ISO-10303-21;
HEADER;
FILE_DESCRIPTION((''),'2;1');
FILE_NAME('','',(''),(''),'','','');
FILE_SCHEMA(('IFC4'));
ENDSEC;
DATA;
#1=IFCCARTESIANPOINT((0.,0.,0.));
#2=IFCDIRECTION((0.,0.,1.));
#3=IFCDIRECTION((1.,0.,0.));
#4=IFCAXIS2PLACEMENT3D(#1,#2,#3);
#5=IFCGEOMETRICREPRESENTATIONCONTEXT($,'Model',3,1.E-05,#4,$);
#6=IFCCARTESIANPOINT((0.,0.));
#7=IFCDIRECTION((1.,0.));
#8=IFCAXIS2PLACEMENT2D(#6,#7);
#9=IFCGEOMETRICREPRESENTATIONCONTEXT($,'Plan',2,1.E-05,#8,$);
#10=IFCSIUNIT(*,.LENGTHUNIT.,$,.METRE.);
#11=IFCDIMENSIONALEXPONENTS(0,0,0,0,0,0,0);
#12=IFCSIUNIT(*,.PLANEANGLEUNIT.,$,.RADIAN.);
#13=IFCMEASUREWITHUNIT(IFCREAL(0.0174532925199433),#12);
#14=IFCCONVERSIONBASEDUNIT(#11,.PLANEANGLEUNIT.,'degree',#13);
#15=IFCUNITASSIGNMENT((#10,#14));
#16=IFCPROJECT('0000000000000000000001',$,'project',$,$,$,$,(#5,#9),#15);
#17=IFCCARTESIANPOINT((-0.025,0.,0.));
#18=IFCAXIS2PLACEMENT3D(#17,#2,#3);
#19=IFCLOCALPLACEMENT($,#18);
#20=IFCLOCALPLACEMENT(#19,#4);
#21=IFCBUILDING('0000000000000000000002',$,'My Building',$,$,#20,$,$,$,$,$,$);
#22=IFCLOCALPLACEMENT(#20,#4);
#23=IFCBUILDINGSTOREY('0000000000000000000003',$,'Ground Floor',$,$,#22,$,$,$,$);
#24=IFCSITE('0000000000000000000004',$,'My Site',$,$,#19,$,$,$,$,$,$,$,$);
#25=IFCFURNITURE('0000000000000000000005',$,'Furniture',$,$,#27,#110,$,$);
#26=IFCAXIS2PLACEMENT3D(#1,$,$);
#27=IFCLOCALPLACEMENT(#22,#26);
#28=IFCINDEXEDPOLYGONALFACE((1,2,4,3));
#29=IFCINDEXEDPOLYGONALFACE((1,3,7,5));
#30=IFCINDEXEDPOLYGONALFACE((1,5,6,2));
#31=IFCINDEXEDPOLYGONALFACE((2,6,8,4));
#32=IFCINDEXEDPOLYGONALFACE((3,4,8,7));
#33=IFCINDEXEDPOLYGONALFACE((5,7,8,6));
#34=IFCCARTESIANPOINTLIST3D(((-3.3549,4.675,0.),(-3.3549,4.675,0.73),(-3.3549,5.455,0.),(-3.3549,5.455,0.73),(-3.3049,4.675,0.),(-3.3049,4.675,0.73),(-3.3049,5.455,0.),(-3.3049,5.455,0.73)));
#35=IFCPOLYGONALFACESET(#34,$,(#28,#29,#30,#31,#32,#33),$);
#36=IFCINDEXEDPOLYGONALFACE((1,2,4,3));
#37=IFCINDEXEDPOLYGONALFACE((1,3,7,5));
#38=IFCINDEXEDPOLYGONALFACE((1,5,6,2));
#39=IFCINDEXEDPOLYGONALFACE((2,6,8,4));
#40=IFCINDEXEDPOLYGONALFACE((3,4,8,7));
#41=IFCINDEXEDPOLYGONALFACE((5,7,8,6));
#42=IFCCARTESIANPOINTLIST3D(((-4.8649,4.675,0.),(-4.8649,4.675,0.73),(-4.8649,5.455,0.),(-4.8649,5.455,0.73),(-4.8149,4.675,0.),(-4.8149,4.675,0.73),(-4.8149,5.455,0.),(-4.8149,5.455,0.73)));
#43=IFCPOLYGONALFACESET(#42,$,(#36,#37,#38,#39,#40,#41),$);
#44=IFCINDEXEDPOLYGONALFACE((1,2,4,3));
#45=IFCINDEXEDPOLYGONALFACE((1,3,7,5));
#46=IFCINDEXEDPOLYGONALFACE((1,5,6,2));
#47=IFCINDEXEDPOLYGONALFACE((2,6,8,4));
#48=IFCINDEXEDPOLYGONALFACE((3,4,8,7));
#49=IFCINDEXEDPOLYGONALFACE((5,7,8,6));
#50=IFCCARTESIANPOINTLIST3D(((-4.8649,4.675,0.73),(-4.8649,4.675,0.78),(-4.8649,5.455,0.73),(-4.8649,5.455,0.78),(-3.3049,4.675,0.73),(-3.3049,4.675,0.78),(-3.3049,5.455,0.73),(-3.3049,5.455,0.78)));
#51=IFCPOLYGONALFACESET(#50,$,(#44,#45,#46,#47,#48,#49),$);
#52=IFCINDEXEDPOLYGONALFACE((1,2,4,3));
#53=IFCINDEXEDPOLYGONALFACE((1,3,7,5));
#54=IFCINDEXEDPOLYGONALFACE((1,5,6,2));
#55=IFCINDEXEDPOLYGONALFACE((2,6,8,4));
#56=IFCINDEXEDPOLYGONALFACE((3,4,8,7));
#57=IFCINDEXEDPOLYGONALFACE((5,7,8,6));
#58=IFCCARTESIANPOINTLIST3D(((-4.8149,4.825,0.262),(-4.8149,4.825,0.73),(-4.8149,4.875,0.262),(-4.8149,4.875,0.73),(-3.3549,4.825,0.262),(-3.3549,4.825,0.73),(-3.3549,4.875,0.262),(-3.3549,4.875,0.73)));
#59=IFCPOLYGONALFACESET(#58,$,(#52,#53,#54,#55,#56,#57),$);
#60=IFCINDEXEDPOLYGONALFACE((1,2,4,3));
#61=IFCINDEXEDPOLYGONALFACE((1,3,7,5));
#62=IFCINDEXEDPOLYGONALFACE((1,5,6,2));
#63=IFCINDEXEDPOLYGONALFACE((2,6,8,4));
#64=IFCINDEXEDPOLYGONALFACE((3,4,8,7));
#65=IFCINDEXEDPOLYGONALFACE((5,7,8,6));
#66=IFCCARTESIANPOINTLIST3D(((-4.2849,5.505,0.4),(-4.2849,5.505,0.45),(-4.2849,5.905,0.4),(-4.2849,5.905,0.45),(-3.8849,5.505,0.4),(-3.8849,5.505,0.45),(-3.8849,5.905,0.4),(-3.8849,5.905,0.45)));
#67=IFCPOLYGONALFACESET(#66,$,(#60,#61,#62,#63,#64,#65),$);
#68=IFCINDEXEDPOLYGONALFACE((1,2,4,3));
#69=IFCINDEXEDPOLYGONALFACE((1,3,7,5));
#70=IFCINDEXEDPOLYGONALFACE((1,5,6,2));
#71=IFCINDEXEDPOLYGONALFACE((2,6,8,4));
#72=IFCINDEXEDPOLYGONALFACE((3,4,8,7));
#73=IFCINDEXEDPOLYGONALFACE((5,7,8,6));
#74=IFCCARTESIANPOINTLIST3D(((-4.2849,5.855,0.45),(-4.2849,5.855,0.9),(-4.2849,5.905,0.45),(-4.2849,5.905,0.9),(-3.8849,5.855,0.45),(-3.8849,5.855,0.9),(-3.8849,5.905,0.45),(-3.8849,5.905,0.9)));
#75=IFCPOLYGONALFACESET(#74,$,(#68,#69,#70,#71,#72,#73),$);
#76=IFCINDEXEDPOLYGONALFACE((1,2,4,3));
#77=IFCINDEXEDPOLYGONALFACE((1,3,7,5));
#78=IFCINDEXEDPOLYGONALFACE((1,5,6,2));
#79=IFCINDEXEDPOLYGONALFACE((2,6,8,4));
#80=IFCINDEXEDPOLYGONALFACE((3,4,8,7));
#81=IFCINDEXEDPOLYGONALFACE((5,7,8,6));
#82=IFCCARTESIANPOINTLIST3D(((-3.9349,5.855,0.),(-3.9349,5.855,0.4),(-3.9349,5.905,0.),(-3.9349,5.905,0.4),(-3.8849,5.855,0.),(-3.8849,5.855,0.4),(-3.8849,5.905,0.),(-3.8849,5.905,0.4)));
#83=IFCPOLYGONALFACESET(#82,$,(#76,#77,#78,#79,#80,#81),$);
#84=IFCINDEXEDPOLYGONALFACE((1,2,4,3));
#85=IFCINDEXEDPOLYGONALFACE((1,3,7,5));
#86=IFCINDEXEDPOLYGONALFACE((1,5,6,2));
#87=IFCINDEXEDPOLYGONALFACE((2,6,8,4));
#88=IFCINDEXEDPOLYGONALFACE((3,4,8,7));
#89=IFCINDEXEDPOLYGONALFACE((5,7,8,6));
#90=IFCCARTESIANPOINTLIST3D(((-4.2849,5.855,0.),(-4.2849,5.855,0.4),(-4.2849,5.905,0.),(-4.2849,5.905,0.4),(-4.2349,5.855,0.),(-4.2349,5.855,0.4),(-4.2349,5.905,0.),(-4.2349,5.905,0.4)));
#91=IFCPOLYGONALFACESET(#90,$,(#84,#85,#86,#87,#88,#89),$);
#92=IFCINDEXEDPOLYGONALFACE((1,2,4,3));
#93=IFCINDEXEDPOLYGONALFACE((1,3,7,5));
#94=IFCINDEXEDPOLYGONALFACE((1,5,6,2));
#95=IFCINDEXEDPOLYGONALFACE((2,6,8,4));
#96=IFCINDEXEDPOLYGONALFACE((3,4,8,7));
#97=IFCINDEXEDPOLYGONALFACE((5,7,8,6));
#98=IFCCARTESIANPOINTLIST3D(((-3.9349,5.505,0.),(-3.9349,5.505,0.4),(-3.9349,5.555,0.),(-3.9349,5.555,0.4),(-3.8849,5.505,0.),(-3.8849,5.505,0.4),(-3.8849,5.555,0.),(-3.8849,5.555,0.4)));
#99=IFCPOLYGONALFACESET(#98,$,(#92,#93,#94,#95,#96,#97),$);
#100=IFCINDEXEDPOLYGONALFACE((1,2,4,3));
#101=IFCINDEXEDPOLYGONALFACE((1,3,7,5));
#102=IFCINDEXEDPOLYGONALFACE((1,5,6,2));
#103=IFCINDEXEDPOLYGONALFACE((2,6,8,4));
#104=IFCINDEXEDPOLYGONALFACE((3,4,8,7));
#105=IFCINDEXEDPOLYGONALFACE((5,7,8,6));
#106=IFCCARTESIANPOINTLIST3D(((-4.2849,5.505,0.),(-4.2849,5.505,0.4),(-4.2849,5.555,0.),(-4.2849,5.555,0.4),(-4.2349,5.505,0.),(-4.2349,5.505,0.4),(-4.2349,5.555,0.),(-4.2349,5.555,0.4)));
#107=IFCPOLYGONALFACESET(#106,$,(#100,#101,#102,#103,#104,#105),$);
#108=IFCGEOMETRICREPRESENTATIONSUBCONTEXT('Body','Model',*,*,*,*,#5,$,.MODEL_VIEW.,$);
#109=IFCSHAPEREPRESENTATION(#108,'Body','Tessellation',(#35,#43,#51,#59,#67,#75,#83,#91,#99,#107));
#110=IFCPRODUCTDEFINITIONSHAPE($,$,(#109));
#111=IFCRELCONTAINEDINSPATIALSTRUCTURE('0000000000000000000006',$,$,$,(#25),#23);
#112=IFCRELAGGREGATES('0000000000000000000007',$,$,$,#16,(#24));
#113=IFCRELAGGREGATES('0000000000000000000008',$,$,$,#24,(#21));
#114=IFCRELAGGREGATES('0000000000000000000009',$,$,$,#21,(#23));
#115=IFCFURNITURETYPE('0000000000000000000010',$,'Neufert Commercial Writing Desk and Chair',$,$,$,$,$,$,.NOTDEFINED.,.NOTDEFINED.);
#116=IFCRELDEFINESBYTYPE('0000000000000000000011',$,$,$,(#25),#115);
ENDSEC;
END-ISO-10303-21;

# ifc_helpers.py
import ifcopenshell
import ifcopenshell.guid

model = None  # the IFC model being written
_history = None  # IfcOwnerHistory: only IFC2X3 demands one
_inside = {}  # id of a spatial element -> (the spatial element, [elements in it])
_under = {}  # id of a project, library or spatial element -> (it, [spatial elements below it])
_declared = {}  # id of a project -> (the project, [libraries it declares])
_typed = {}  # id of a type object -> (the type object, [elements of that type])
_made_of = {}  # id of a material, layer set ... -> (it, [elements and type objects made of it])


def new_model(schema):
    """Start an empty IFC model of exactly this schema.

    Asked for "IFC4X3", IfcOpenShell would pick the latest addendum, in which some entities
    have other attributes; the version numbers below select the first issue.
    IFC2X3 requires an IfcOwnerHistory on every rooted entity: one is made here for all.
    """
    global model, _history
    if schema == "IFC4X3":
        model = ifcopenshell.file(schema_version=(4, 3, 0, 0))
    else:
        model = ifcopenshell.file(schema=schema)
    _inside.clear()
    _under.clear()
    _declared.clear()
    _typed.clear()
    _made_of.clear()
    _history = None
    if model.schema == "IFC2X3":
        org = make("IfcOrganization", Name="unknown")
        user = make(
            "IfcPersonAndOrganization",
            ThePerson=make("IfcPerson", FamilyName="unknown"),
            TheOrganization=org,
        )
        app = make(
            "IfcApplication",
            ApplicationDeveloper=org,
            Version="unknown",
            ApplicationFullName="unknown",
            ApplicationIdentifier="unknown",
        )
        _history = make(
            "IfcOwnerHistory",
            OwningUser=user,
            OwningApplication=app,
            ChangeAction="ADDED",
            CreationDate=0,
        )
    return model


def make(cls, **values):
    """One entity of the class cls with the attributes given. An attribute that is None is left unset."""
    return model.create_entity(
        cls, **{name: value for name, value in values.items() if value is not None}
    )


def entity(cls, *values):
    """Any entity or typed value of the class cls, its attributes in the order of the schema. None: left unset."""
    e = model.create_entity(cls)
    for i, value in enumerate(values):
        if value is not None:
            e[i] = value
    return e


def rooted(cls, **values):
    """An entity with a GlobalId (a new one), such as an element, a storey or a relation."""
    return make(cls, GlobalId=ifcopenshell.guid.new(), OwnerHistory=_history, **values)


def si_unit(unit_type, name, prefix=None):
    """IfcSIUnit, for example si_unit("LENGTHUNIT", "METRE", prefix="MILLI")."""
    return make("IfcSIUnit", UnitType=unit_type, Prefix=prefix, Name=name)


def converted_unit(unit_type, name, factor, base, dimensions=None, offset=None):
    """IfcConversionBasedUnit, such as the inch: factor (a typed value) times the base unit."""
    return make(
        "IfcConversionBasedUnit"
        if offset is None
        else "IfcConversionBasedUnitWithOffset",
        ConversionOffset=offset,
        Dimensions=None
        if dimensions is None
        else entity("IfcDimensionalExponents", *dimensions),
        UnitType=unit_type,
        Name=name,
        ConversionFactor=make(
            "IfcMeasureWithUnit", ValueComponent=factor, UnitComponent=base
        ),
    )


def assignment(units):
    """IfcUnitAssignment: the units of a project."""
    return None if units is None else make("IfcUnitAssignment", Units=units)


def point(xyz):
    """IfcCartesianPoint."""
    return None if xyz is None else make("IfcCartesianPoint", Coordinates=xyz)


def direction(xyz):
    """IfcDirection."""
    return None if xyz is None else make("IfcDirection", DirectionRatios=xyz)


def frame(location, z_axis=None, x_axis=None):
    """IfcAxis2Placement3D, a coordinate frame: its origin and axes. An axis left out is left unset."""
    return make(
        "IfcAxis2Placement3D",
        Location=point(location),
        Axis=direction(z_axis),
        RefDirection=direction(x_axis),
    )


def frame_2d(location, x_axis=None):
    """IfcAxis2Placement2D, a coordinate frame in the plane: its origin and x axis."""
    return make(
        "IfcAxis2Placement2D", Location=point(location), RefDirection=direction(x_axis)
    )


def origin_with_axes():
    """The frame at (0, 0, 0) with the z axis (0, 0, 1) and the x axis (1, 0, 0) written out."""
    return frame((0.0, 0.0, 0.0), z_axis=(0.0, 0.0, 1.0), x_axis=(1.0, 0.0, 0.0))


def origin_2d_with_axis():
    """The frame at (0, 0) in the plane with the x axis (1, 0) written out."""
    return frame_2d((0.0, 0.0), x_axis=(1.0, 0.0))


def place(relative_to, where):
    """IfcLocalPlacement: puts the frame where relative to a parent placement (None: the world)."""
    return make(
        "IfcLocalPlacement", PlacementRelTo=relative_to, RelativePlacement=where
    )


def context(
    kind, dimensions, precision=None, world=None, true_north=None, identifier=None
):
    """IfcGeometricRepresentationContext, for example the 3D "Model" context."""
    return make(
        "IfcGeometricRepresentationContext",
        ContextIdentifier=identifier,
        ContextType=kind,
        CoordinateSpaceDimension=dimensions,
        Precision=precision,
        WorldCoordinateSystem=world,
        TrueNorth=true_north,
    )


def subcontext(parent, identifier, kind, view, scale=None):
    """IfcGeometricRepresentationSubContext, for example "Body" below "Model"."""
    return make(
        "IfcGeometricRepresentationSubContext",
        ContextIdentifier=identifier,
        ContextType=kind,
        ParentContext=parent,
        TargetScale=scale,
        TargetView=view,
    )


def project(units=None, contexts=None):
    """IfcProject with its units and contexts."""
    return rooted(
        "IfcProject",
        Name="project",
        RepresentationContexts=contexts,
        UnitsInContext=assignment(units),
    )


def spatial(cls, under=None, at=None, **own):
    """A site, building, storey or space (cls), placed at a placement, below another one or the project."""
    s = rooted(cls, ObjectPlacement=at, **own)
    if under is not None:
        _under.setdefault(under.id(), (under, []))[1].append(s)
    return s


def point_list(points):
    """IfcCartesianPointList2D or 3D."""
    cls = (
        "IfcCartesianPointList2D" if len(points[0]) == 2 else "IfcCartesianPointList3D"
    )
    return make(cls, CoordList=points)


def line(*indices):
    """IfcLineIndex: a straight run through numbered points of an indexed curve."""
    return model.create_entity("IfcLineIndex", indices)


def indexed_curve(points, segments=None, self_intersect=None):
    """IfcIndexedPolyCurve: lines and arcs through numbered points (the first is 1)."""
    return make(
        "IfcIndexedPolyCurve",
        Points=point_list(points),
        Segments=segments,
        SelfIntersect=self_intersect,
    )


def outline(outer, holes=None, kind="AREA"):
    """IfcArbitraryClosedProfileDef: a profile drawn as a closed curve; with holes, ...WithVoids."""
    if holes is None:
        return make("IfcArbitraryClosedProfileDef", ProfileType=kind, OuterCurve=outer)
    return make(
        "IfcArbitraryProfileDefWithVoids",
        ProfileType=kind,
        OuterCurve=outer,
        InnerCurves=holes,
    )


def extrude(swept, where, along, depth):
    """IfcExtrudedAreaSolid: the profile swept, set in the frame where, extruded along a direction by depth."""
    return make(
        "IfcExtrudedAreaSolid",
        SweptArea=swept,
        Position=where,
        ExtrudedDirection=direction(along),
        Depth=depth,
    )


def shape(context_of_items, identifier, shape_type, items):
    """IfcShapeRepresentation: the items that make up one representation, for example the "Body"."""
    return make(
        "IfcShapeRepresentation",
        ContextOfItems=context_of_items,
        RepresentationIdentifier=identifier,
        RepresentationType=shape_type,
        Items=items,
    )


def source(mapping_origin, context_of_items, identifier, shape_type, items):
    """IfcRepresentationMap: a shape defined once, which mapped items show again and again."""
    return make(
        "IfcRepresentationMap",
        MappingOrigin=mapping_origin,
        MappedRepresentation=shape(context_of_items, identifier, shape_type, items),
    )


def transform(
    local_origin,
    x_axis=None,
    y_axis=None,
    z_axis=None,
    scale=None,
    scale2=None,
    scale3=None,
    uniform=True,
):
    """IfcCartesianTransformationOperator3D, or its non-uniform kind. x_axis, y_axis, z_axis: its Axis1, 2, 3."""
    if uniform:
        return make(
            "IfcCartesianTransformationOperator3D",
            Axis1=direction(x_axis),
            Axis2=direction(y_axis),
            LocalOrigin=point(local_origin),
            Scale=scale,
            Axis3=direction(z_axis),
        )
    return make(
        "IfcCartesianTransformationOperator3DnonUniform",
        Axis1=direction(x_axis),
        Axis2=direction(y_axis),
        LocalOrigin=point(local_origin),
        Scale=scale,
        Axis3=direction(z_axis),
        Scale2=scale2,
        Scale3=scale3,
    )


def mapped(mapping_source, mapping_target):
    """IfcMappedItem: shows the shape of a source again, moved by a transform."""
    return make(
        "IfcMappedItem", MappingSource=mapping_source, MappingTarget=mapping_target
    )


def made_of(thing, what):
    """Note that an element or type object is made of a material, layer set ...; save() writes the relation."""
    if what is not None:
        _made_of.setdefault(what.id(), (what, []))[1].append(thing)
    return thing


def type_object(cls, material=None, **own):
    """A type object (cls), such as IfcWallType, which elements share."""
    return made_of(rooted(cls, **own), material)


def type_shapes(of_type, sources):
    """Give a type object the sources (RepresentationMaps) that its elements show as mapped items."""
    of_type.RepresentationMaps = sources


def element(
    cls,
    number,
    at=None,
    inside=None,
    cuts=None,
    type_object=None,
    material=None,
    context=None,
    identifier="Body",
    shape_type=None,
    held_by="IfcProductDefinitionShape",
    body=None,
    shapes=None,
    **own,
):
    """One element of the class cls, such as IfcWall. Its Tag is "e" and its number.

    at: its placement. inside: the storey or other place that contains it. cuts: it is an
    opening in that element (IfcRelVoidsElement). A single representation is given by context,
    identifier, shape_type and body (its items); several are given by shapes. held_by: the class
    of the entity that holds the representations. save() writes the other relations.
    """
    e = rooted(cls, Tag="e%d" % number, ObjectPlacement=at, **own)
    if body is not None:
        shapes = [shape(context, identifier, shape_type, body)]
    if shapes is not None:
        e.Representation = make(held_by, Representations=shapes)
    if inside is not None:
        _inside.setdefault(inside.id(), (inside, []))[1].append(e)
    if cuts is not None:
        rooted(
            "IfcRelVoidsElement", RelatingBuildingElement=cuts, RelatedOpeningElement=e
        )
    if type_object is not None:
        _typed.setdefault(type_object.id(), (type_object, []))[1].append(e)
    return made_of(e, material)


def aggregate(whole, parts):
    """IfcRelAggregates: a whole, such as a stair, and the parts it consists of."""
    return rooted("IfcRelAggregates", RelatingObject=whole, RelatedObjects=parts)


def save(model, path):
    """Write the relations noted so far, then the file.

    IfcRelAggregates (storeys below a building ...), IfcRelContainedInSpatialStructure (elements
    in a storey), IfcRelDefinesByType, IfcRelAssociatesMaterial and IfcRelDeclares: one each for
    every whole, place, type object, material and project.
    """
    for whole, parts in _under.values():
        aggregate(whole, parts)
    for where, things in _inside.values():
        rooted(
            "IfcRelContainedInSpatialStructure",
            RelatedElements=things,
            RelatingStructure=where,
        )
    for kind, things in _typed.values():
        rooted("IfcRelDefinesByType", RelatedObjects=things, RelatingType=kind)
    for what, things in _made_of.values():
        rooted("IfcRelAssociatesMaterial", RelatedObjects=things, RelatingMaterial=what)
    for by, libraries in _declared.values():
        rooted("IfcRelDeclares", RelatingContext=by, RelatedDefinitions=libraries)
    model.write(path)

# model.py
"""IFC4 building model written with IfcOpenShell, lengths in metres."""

from ifc_helpers import new_model, entity, si_unit, converted_unit, frame, origin_with_axes, origin_2d_with_axis, place, context, subcontext, project, spatial, line, indexed_curve, outline, extrude, shape, source, transform, mapped, type_object, type_shapes, element, save


model = new_model("IFC4")

# Units and contexts
model_context = context("Model", 3, precision=1e-05, world=origin_with_axes())
plan_context = context("Plan", 2, precision=1e-05, world=origin_2d_with_axis())
body_context_1 = subcontext(model_context, "Body", "Model", "MODEL_VIEW")
body_context_2 = subcontext(plan_context, "Body", "Plan", "PLAN_VIEW")
ifc_project = project(units=[si_unit("LENGTHUNIT", "METRE"), converted_unit("PLANEANGLEUNIT", "degree", entity("IfcReal", 0.0174532925199433), si_unit("PLANEANGLEUNIT", "RADIAN"), dimensions=[0, 0, 0, 0, 0, 0, 0])], contexts=[model_context, plan_context])

# Site, building, storey
site_placement = place(None, frame((-0.025, 0.0, 0.0), z_axis=(0.0, 0.0, 1.0), x_axis=(1.0, 0.0, 0.0)))
site = spatial("IfcSite", under=ifc_project, at=site_placement, Name="My Site")
building_placement = place(site_placement, origin_with_axes())
building = spatial("IfcBuilding", under=site, at=building_placement, Name="My Building")
storey_placement = place(building_placement, frame((0.0, 0.0, 0.0), z_axis=(0.0, 0.0, 1.0), x_axis=(1.0, 0.0, 0.0)))
storey = spatial("IfcBuildingStorey", under=building, at=storey_placement, Name="Ground Floor")

# Furniture
furniture_type_1 = type_object("IfcFurnitureType", Name="Neufert Commercial Writing Desk and Chair", AssemblyPlace="NOTDEFINED", PredefinedType="NOTDEFINED")
shared_shape_1 = source(origin_with_axes(), body_context_1, "Body", "SweptSolid", [
    extrude(outline(indexed_curve([(0.0, 0.0), (0.05, 0.0), (0.05, 0.78), (0.0, 0.78)], segments=[line(1, 2, 3, 4, 1)])), frame((0.0, 0.45, 0.0), z_axis=(0.0, 0.0, 1.0), x_axis=(1.0, 0.0, 0.0)), (0.0, 0.0, 1.0), 0.73),
    extrude(outline(indexed_curve([(0.0, 0.0), (0.05, 0.0), (0.05, 0.78), (0.0, 0.78)], segments=[line(1, 2, 3, 4, 1)])), frame((1.51, 0.45, 0.0), z_axis=(0.0, 0.0, 1.0), x_axis=(1.0, 0.0, 0.0)), (0.0, 0.0, 1.0), 0.73),
    extrude(outline(indexed_curve([(0.0, 0.0), (1.56, 0.0), (1.56, 0.78), (0.0, 0.78)], segments=[line(1, 2, 3, 4, 1)])), frame((0.0, 0.45, 0.73), z_axis=(0.0, 0.0, 1.0), x_axis=(1.0, 0.0, 0.0)), (0.0, 0.0, 1.0), 0.05),
    extrude(outline(indexed_curve([(0.05, 0.58), (1.51, 0.58), (1.51, 0.63), (0.05, 0.63)], segments=[line(1, 2, 3, 4, 1)])), frame((0.0, 0.45, 0.262), z_axis=(0.0, 0.0, 1.0), x_axis=(1.0, 0.0, 0.0)), (0.0, 0.0, 1.0), 0.468),
    extrude(outline(indexed_curve([(-0.2, 0.0), (0.2, 0.0), (0.2, 0.4), (-0.2, 0.4)], segments=[line(1, 2, 3, 4, 1)])), frame((0.78, 0.0, 0.45), z_axis=(0.0, 0.0, 1.0), x_axis=(1.0, 0.0, 0.0)), (0.0, 0.0, -1.0), 0.05),
    extrude(outline(indexed_curve([(-0.2, 0.0), (0.2, 0.0), (0.2, 0.05), (-0.2, 0.05)], segments=[line(1, 2, 3, 4, 1)])), frame((0.78, 0.0, 0.9), z_axis=(0.0, 0.0, 1.0), x_axis=(1.0, 0.0, 0.0)), (0.0, 0.0, -1.0), 0.45),
    extrude(outline(indexed_curve([(-0.2, 0.0), (-0.15, 0.0), (-0.15, 0.05), (-0.2, 0.05)], segments=[line(1, 2, 3, 4, 1)])), frame((0.78, 0.0, 0.0), z_axis=(0.0, 0.0, 1.0), x_axis=(1.0, 0.0, 0.0)), (0.0, 0.0, 1.0), 0.4),
    extrude(outline(indexed_curve([(0.2, 0.0), (0.15, 0.0), (0.15, 0.05), (0.2, 0.05)], segments=[line(1, 2, 3, 4, 1)])), frame((0.78, 0.0, 0.0), z_axis=(0.0, 0.0, 1.0), x_axis=(1.0, 0.0, 0.0)), (0.0, 0.0, 1.0), 0.4),
    extrude(outline(indexed_curve([(-0.2, 0.4), (-0.15, 0.4), (-0.15, 0.35), (-0.2, 0.35)], segments=[line(1, 2, 3, 4, 1)])), frame((0.78, 0.0, 0.0), z_axis=(0.0, 0.0, 1.0), x_axis=(1.0, 0.0, 0.0)), (0.0, 0.0, 1.0), 0.4),
    extrude(outline(indexed_curve([(0.2, 0.4), (0.15, 0.4), (0.15, 0.35), (0.2, 0.35)], segments=[line(1, 2, 3, 4, 1)])), frame((0.78, 0.0, 0.0), z_axis=(0.0, 0.0, 1.0), x_axis=(1.0, 0.0, 0.0)), (0.0, 0.0, 1.0), 0.4),
])
shared_shape_2 = source(origin_with_axes(), body_context_2, "Body", "Curve2D", [
    entity("IfcIndexedPolyCurve", entity("IfcCartesianPointList2D", [[0.0, 0.45], [1.56, 0.45], [1.56, 1.23], [0.0, 1.23]]), [entity("IfcLineIndex", [1, 2, 3, 4, 1])]),
    entity("IfcIndexedPolyCurve", entity("IfcCartesianPointList2D", [[0.58, 0.4], [0.98, 0.4]])),
    entity("IfcIndexedPolyCurve", entity("IfcCartesianPointList2D", [[0.58, 0.4], [0.58, 0.2], [0.6386, 0.0586], [0.78, 0.0], [0.9214, 0.0586], [0.98, 0.2], [0.98, 0.4]]), [entity("IfcLineIndex", [1, 2]), entity("IfcArcIndex", [2, 3, 4]), entity("IfcArcIndex", [4, 5, 6]), entity("IfcLineIndex", [6, 7])]),
    entity("IfcIndexedPolyCurve", entity("IfcCartesianPointList2D", [[0.62, 0.4], [0.62, 0.2], [0.6669, 0.0869], [0.78, 0.04], [0.8931, 0.0869], [0.94, 0.2], [0.94, 0.4]]), [entity("IfcLineIndex", [1, 2]), entity("IfcArcIndex", [2, 3, 4]), entity("IfcArcIndex", [4, 5, 6]), entity("IfcLineIndex", [6, 7])]),
])
type_shapes(furniture_type_1, [shared_shape_1, shared_shape_2])
for number, where, z_axis, x_axis, name in (
    (1, (-3.3049, 5.905, 0.0), (0.0, 0.0, 1.0), (-1.0, 0.0, 0.0), "Furniture"),
):
    element("IfcFurniture", number, at=place(storey_placement, frame(where, z_axis=z_axis, x_axis=x_axis)), inside=storey, type_object=furniture_type_1, Name=name, shapes=[
        shape(body_context_1, "Body", "MappedRepresentation", [mapped(shared_shape_1, transform((0.0, 0.0, 0.0), x_axis=(1.0, 0.0, 0.0), y_axis=(0.0, 1.0, 0.0), z_axis=(0.0, 0.0, 1.0), scale=1.0))]),
        shape(body_context_2, "Body", "MappedRepresentation", [mapped(shared_shape_2, transform((0.0, 0.0, 0.0), x_axis=(1.0, 0.0, 0.0), y_axis=(0.0, 1.0, 0.0), z_axis=(0.0, 0.0, 1.0), scale=1.0))]),
    ])

save(model, "model.ifc")
